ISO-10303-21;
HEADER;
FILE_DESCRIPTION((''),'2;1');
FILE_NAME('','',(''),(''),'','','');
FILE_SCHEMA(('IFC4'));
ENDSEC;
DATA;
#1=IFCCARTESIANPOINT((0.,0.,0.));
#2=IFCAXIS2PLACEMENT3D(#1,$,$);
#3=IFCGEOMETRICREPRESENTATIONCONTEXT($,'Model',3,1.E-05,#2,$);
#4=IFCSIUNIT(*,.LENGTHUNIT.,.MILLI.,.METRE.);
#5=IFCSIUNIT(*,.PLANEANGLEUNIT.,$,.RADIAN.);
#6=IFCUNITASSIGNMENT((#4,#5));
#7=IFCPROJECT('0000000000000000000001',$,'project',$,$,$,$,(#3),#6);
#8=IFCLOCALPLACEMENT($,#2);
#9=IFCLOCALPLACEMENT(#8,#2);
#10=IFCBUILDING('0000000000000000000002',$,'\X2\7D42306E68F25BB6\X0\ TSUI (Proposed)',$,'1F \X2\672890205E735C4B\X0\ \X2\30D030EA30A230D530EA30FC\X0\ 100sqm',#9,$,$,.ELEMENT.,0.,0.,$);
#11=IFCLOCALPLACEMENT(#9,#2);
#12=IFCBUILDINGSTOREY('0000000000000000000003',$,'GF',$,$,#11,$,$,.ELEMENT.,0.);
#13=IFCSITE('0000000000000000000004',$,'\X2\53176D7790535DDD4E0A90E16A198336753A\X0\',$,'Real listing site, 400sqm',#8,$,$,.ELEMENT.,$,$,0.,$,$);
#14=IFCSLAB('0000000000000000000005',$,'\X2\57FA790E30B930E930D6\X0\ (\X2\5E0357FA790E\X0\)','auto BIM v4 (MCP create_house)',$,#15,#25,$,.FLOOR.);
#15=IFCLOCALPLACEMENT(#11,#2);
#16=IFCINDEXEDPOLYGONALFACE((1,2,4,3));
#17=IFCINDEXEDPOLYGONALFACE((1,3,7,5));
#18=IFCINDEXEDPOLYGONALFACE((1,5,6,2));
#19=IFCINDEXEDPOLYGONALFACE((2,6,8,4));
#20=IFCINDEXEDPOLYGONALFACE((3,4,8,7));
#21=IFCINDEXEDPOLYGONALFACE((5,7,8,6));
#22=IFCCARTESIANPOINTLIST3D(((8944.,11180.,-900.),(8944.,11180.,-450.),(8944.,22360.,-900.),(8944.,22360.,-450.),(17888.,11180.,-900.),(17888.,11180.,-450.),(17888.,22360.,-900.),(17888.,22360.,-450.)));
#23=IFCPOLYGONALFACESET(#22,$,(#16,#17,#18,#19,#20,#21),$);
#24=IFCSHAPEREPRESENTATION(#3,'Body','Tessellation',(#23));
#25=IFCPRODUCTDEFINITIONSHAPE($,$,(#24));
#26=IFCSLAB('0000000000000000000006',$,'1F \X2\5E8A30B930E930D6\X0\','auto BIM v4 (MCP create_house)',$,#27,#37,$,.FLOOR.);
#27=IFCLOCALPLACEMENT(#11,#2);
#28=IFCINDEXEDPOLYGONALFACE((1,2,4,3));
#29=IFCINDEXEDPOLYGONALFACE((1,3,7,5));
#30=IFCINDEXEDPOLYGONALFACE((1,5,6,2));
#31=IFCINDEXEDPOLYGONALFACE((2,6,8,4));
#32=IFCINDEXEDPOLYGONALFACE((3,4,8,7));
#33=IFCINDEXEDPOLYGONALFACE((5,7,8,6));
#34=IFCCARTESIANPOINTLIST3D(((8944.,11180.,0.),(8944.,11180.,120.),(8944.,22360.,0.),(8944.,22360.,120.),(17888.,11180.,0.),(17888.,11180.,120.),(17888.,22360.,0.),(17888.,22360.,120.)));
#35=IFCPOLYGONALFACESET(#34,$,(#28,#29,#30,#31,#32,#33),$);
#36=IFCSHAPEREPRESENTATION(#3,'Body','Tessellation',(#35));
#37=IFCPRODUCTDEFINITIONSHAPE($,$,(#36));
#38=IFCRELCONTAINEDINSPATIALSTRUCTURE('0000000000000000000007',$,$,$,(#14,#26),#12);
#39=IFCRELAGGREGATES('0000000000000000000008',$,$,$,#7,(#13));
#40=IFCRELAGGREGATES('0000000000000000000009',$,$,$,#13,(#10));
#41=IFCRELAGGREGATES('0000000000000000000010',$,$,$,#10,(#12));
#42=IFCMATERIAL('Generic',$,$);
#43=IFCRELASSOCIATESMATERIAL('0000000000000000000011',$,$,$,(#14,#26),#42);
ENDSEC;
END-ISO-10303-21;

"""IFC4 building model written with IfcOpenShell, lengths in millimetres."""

from ifc_helpers import new_model, si_unit, frame, frame_2d, origin, place, context, project, spatial, rectangle, extrude, material, element, save


model = new_model("IFC4")

# Units and contexts
model_context = context("Model", 3, precision=1e-05, world=origin())
ifc_project = project(units=[si_unit("LENGTHUNIT", "METRE", prefix="MILLI"), si_unit("PLANEANGLEUNIT", "RADIAN")], contexts=[model_context])

# Site, building, storey
site_placement = place(None, origin())
site = spatial("IfcSite", under=ifc_project, at=site_placement, Name="北海道川上郡標茶町", ObjectType="Real listing site, 400sqm", CompositionType="ELEMENT", RefElevation=0.0)
building_placement = place(site_placement, origin())
building = spatial("IfcBuilding", under=site, at=building_placement, Name="終の棲家 TSUI (Proposed)", ObjectType="1F 木造平屋 バリアフリー 100sqm", CompositionType="ELEMENT", ElevationOfRefHeight=0.0, ElevationOfTerrain=0.0)
storey_placement = place(building_placement, origin())
storey = spatial("IfcBuildingStorey", under=building, at=storey_placement, Name="GF", CompositionType="ELEMENT", Elevation=0.0)

# Slabs
ifc_material = material(Name="Generic")
slab_1_placement = place(storey_placement, frame((4472.0, 5590.0, -450.0)))
element("IfcSlab", 1, at=slab_1_placement, inside=storey, material=ifc_material, Name="基礎スラブ (布基礎)", Description="auto BIM v4 (MCP create_house)", PredefinedType="FLOOR", context=model_context, shape_type="SweptSolid", body=[
    extrude(rectangle(XDim=8944.0, YDim=11180.0, at=frame_2d((4472.0, 5590.0))), frame((4472.0, 5590.0, -450.0)), (0.0, 0.0, 1.0), 450.0),
])
slab_2_placement = place(storey_placement, frame((4472.0, 5590.0, 0.0)))
element("IfcSlab", 2, at=slab_2_placement, inside=storey, material=ifc_material, Name="1F 床スラブ", Description="auto BIM v4 (MCP create_house)", PredefinedType="FLOOR", context=model_context, shape_type="SweptSolid", body=[
    extrude(rectangle(XDim=8944.0, YDim=11180.0, at=frame_2d((4472.0, 5590.0))), frame((4472.0, 5590.0, 0.0)), (0.0, 0.0, 1.0), 120.0),
])

save(model, "model.ifc")
